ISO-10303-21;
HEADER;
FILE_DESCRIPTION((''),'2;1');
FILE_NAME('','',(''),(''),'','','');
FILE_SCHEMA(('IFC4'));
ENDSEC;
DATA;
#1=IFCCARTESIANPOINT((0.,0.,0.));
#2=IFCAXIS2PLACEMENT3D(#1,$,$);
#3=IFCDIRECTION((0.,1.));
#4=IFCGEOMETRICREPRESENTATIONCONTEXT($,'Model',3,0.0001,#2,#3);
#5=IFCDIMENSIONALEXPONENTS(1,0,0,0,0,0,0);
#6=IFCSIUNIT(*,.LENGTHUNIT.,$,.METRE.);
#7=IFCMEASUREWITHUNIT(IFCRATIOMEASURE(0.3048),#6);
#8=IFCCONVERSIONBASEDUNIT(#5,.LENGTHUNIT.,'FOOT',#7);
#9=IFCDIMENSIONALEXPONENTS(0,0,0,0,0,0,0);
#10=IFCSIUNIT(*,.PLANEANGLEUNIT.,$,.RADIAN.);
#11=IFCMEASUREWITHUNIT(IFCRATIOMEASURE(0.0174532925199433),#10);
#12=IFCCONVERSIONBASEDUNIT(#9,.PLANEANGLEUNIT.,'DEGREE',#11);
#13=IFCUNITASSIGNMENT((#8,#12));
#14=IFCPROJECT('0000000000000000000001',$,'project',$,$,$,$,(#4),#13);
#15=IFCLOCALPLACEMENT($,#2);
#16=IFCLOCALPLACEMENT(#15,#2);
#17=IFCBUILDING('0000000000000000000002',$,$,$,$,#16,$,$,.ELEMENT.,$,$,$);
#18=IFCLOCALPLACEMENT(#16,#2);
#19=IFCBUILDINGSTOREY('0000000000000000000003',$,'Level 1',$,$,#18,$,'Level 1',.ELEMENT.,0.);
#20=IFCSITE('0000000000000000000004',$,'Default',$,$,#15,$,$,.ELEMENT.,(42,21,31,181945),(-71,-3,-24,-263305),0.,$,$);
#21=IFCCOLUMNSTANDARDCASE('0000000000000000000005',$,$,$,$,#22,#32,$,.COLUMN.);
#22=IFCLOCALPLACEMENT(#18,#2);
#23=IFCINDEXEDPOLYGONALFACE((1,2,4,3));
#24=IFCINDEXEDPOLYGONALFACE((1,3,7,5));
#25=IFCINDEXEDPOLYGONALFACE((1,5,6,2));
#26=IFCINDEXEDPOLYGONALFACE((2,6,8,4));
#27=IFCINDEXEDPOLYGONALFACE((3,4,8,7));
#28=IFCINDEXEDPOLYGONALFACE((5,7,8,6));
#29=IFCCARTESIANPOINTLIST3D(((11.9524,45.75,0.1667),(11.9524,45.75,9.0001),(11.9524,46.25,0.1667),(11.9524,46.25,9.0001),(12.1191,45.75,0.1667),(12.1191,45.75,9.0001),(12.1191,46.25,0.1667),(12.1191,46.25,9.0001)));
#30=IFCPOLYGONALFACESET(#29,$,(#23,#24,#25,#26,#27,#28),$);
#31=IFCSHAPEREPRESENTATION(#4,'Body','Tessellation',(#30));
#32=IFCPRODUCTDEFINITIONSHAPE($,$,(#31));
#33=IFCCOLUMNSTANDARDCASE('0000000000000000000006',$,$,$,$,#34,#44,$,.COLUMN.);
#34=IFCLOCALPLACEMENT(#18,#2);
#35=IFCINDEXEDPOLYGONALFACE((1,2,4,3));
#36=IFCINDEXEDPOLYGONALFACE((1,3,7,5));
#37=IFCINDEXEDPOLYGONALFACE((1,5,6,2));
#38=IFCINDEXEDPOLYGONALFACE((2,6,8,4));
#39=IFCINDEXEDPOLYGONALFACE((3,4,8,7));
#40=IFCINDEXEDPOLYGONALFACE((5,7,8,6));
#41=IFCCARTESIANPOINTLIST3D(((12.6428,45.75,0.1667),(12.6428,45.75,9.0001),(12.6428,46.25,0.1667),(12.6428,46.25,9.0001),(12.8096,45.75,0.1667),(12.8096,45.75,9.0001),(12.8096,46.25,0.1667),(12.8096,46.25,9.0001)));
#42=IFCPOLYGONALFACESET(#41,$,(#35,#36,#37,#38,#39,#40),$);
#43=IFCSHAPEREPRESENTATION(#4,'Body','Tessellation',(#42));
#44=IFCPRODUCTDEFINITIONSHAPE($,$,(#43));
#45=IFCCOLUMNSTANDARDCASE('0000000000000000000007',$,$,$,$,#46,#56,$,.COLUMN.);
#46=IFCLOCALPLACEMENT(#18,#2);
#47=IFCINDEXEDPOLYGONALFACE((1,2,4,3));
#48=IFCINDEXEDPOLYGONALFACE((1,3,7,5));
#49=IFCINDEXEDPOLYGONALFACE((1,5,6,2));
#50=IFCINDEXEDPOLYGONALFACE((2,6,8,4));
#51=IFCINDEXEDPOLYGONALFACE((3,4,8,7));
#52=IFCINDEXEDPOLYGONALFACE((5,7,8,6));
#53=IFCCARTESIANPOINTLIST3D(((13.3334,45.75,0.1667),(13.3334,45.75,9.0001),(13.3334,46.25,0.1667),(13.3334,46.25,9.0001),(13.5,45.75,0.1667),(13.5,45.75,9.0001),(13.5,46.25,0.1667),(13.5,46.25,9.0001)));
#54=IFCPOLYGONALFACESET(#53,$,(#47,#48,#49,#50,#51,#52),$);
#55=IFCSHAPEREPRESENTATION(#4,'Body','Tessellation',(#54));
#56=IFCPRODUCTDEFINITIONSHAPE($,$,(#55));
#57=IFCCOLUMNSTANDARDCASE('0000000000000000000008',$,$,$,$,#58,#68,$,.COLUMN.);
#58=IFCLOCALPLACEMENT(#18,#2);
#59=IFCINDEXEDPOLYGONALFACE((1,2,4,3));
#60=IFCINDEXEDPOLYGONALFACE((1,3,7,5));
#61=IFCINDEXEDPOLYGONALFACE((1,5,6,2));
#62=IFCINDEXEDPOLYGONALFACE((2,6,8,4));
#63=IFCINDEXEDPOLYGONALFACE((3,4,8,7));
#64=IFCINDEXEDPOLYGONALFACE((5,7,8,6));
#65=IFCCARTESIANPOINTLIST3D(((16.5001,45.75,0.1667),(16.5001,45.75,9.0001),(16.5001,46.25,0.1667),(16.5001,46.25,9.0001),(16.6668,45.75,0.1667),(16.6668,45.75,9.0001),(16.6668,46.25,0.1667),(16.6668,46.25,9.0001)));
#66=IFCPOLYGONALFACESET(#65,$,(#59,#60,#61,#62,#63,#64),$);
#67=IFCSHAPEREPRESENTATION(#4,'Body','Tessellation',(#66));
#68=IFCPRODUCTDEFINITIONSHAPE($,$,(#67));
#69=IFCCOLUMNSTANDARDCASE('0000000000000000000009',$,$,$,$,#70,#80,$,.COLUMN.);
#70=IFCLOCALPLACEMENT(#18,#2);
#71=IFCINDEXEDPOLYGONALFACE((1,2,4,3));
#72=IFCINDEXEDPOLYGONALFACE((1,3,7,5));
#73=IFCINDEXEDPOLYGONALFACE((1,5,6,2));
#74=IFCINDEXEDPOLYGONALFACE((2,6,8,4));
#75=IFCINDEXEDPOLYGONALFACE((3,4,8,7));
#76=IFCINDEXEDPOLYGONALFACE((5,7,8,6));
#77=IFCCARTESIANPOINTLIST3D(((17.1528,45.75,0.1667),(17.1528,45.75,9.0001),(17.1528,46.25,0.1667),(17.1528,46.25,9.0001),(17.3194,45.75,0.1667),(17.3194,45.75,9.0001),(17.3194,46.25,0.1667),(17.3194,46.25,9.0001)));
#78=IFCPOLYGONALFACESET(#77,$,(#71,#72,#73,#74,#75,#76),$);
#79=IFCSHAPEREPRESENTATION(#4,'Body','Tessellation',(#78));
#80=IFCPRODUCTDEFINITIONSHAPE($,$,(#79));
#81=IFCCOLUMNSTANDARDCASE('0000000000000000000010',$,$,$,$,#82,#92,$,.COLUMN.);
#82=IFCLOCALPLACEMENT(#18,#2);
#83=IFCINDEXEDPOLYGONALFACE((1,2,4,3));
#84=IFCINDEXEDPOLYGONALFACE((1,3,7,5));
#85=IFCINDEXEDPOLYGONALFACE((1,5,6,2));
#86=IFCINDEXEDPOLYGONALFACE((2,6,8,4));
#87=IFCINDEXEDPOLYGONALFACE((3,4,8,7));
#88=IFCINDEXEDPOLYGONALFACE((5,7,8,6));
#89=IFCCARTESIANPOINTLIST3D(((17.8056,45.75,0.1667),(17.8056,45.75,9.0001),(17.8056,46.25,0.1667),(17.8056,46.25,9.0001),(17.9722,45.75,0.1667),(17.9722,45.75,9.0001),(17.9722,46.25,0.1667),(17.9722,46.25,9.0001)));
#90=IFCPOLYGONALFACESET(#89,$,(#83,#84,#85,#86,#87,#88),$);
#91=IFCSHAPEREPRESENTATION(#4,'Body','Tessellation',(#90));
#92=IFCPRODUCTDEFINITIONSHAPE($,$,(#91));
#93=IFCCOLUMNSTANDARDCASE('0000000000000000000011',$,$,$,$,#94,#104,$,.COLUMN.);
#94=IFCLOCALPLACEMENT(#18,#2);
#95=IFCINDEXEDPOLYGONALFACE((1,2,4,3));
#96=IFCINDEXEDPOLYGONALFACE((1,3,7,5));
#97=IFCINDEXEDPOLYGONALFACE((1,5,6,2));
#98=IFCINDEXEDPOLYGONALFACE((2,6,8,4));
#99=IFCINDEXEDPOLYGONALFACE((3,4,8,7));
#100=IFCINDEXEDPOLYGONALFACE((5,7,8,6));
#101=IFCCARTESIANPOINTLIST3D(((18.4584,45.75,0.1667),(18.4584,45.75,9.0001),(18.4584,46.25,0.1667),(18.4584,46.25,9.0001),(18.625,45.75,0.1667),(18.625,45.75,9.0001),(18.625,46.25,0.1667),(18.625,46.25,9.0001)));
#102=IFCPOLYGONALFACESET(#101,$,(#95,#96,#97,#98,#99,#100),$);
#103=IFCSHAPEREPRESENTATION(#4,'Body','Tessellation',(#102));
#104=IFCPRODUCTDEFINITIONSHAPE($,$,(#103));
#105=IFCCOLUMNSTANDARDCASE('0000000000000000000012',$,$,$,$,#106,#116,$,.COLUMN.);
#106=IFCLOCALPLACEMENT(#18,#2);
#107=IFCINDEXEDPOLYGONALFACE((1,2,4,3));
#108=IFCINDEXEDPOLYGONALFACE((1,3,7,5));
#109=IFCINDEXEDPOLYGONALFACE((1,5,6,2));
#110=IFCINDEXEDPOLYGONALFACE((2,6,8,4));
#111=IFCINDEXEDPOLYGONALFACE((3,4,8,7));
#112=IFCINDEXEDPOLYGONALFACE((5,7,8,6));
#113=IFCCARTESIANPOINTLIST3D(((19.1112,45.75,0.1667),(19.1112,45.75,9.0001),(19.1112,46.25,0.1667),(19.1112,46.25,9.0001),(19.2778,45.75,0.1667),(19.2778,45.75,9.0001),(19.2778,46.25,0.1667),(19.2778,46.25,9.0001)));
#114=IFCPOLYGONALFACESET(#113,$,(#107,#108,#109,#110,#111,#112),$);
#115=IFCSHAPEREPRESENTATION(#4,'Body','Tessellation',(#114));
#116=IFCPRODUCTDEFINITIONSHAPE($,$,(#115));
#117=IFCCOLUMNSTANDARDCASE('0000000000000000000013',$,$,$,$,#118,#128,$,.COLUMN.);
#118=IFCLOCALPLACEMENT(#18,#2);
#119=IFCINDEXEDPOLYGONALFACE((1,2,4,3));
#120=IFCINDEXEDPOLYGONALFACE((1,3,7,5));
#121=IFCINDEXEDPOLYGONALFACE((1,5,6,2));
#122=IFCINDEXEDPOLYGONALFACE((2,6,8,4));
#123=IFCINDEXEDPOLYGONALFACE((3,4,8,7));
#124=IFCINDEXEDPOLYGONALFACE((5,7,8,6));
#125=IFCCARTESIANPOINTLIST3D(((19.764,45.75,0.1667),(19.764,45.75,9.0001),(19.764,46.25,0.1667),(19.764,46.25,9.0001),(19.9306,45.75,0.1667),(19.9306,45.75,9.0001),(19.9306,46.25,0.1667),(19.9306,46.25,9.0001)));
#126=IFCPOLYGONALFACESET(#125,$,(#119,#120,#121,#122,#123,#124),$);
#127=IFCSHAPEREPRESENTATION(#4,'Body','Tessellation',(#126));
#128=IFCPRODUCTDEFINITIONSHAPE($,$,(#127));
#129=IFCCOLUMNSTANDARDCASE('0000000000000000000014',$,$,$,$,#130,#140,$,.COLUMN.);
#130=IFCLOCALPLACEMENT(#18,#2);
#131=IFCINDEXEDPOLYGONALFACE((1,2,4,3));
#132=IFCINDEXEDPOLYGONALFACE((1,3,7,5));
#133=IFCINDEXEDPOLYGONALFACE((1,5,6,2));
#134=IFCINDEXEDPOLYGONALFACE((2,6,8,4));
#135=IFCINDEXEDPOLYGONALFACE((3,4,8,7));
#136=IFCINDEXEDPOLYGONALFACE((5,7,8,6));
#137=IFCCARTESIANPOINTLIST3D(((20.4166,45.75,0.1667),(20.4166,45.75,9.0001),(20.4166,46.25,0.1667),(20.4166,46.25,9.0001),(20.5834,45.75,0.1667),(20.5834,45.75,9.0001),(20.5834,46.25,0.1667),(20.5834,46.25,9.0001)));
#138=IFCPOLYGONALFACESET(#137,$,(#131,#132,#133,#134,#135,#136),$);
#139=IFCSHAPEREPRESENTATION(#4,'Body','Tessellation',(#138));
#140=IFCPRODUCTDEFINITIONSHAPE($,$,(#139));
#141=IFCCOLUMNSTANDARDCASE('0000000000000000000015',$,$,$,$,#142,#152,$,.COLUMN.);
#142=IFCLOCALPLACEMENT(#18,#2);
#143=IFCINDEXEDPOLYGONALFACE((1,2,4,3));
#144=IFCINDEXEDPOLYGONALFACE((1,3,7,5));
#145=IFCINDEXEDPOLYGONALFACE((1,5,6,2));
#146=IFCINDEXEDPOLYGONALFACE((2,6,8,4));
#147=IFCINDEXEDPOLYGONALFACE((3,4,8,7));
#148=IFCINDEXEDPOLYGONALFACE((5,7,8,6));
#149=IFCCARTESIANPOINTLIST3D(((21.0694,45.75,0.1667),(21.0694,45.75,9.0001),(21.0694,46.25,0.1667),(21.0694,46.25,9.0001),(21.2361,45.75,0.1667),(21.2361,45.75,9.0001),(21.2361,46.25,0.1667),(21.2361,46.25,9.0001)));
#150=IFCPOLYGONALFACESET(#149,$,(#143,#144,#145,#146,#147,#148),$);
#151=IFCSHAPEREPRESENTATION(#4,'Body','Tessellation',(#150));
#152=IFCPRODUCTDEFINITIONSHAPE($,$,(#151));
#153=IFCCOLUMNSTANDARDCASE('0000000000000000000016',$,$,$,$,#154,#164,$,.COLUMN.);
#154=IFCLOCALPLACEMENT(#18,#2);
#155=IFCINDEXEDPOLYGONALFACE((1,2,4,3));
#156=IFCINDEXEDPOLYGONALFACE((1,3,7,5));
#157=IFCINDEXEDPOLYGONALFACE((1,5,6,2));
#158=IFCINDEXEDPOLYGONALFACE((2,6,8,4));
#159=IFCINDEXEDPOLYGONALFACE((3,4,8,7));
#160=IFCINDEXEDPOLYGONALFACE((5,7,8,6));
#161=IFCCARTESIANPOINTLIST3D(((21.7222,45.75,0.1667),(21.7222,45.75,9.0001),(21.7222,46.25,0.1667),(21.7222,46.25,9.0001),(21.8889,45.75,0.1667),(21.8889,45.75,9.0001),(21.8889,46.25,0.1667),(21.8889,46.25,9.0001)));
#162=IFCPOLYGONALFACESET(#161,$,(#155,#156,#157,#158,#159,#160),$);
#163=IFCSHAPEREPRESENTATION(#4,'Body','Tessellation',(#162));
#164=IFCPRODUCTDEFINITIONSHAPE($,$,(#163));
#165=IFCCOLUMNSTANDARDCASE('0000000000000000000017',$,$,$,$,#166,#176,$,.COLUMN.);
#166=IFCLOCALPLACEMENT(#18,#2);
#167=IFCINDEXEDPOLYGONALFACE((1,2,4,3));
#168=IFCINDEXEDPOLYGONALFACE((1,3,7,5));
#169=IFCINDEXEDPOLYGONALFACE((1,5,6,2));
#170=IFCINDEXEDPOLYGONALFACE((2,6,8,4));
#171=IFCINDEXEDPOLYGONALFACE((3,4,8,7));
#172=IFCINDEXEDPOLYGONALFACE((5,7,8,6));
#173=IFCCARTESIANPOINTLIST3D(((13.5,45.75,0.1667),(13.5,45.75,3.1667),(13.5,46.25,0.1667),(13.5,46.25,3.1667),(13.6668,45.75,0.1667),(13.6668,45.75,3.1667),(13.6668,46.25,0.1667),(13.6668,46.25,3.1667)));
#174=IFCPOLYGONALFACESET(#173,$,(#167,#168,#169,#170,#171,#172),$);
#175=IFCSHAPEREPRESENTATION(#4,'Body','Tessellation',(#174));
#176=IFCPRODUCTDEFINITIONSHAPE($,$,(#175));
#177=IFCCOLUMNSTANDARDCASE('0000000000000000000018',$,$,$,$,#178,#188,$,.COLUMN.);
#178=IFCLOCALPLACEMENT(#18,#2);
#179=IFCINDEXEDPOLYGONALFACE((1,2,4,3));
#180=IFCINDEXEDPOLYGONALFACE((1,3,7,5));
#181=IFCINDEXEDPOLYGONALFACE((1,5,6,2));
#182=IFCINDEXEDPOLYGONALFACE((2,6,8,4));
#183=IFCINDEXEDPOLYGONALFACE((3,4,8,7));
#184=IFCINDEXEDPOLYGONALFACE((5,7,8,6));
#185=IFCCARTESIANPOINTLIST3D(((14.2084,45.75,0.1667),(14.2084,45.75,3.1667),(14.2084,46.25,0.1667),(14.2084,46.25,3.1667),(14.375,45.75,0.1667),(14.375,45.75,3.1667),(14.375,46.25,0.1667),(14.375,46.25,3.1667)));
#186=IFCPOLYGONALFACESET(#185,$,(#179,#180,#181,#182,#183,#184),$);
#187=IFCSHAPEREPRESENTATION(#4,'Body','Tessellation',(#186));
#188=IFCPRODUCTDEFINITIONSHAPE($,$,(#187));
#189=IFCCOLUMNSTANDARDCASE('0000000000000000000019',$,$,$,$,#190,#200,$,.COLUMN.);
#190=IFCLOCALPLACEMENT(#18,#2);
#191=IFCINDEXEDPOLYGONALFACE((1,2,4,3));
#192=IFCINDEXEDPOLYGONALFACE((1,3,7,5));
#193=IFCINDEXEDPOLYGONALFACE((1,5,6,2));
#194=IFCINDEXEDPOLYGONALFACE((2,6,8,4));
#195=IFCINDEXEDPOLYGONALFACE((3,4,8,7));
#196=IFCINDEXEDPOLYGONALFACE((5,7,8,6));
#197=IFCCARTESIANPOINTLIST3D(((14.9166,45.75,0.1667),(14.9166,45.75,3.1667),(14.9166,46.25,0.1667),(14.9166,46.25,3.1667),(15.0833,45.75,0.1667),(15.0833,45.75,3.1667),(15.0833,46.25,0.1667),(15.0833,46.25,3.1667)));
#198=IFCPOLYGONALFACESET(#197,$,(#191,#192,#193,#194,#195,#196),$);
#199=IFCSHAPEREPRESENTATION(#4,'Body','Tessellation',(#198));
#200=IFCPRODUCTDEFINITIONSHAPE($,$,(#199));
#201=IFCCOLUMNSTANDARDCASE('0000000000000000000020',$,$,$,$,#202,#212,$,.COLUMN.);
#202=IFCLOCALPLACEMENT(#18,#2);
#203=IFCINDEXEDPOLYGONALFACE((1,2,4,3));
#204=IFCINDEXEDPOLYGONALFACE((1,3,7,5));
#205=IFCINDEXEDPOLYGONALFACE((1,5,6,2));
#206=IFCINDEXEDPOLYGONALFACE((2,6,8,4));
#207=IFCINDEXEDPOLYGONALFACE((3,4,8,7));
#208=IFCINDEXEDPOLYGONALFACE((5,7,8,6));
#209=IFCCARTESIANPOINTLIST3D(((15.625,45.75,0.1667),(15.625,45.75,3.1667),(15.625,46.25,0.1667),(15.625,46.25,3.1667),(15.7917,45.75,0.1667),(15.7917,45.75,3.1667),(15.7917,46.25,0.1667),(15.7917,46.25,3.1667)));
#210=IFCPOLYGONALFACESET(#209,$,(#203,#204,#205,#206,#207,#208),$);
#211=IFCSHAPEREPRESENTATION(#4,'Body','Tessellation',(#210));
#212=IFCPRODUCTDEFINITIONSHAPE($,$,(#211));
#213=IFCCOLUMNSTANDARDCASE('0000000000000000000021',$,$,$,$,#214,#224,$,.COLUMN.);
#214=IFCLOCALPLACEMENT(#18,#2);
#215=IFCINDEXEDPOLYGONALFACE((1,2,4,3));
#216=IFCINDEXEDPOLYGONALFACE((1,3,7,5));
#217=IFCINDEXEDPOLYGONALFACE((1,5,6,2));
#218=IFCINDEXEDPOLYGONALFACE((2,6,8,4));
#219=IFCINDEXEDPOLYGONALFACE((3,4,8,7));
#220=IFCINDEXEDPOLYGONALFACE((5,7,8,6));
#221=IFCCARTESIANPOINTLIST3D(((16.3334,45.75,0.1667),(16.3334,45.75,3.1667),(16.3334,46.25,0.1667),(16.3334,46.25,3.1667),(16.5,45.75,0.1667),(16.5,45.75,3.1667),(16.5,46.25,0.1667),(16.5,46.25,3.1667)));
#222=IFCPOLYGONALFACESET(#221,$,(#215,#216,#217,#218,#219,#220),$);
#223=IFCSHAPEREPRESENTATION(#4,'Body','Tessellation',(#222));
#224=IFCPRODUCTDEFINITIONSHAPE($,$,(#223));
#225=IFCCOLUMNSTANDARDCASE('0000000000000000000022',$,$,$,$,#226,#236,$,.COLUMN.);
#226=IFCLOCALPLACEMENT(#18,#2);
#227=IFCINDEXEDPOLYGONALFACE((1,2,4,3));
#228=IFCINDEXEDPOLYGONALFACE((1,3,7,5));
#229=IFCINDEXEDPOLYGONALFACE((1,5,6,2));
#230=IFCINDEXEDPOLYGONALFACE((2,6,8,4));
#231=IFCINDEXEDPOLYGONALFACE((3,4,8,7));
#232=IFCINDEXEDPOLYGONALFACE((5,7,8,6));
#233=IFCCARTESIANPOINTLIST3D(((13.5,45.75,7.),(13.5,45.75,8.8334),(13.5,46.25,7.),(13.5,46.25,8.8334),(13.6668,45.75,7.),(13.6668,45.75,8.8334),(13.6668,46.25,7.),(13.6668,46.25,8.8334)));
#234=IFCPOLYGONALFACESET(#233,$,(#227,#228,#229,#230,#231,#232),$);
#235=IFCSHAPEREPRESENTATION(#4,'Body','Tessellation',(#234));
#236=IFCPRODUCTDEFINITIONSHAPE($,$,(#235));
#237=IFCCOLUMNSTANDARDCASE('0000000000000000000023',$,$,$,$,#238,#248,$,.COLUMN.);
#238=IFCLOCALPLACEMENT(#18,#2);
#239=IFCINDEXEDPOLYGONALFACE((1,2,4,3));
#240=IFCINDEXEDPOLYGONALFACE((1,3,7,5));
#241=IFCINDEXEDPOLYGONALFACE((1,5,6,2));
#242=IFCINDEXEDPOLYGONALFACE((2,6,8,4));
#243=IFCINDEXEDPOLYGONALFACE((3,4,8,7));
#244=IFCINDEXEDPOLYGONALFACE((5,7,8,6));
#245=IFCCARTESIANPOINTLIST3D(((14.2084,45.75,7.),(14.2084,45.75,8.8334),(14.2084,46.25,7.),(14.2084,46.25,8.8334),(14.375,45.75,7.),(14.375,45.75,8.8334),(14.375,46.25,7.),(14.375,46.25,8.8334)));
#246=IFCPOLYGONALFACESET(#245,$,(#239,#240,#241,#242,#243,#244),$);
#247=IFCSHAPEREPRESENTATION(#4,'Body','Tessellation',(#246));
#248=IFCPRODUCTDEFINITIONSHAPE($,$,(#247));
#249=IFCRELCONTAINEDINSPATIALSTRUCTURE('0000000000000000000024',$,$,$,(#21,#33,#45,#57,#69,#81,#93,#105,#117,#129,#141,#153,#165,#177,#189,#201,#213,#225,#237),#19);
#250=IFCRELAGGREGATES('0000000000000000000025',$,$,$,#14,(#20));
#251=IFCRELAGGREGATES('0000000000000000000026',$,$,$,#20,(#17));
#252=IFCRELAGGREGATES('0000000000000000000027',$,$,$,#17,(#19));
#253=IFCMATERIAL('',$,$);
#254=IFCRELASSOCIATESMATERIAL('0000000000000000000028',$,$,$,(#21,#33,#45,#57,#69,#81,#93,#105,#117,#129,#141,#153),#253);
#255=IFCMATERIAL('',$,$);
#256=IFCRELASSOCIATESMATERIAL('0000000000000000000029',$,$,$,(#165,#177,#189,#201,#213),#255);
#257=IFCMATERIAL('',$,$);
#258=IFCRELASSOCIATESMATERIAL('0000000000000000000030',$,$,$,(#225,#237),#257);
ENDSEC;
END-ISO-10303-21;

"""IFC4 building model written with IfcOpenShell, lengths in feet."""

from ifc_helpers import new_model, entity, si_unit, converted_unit, direction, frame, origin, place, context, project, spatial, rectangle, extrude, material, element, save


model = new_model("IFC4")

# Units and contexts
model_context = context("Model", 3, precision=0.0001, world=origin(), true_north=direction((0.0, 1.0)))
ifc_project = project(units=[converted_unit("LENGTHUNIT", "FOOT", entity("IfcRatioMeasure", 0.3048), si_unit("LENGTHUNIT", "METRE"), dimensions=[1, 0, 0, 0, 0, 0, 0]), converted_unit("PLANEANGLEUNIT", "DEGREE", entity("IfcRatioMeasure", 0.0174532925199433), si_unit("PLANEANGLEUNIT", "RADIAN"), dimensions=[0, 0, 0, 0, 0, 0, 0])], contexts=[model_context])

# Site, building, storey
site_placement = place(None, origin())
site = spatial("IfcSite", under=ifc_project, at=site_placement, Name="Default", CompositionType="ELEMENT", RefLatitude=(42, 21, 31, 181945), RefLongitude=(-71, -3, -24, -263305), RefElevation=0.0)
building_placement = place(site_placement, origin())
building = spatial("IfcBuilding", under=site, at=building_placement, CompositionType="ELEMENT")
storey_placement = place(building_placement, origin())
storey = spatial("IfcBuildingStorey", under=building, at=storey_placement, Name="Level 1", LongName="Level 1", CompositionType="ELEMENT", Elevation=0.0)

# Columns
ifc_material_1 = material(Name="")
placement_1 = place(storey_placement, frame((-0.25, 46.0, 0.0)))
for number, where, z_axis, x_axis in (
    (1, (12.2857, 0.0, 0.1667), (0.0, 0.0, 1.0), (1.0, 0.0, 0.0)),
    (2, (12.9762, 0.0, 0.1667), (0.0, 0.0, 1.0), (1.0, 0.0, 0.0)),
    (3, (13.6667, 0.0, 0.1667), (0.0, 0.0, 1.0), (1.0, 0.0, 0.0)),
    (4, (16.8334, 0.0, 0.1667), (0.0, 0.0, 1.0), (1.0, 0.0, 0.0)),
    (5, (17.4861, 0.0, 0.1667), (0.0, 0.0, 1.0), (1.0, 0.0, 0.0)),
    (6, (18.1389, 0.0, 0.1667), (0.0, 0.0, 1.0), (1.0, 0.0, 0.0)),
    (7, (18.7917, 0.0, 0.1667), (0.0, 0.0, 1.0), (1.0, 0.0, 0.0)),
    (8, (19.4445, 0.0, 0.1667), (0.0, 0.0, 1.0), (1.0, 0.0, 0.0)),
    (9, (20.0973, 0.0, 0.1667), (0.0, 0.0, 1.0), (1.0, 0.0, 0.0)),
    (10, (20.75, 0.0, 0.1667), (0.0, 0.0, 1.0), (1.0, 0.0, 0.0)),
    (11, (21.4028, 0.0, 0.1667), (0.0, 0.0, 1.0), (1.0, 0.0, 0.0)),
    (12, (22.0556, 0.0, 0.1667), (0.0, 0.0, 1.0), (1.0, 0.0, 0.0)),
):
    element("IfcColumnStandardCase", number, at=place(placement_1, frame(where, z_axis=z_axis, x_axis=x_axis)), inside=storey, material=ifc_material_1, PredefinedType="COLUMN", context=model_context, shape_type="SweptSolid", body=[
        extrude(rectangle(XDim=0.1667, YDim=0.5), origin(), (0.0, 0.0, 1.0), 8.8334),
    ])
ifc_material_2 = material(Name="")
for number, where, z_axis, x_axis in (
    (13, (13.8334, 0.0, 0.1667), (0.0, 0.0, 1.0), (1.0, 0.0, 0.0)),
    (14, (14.5417, 0.0, 0.1667), (0.0, 0.0, 1.0), (1.0, 0.0, 0.0)),
    (15, (15.25, 0.0, 0.1667), (0.0, 0.0, 1.0), (1.0, 0.0, 0.0)),
    (16, (15.9584, 0.0, 0.1667), (0.0, 0.0, 1.0), (1.0, 0.0, 0.0)),
    (17, (16.6667, 0.0, 0.1667), (0.0, 0.0, 1.0), (1.0, 0.0, 0.0)),
):
    element("IfcColumnStandardCase", number, at=place(placement_1, frame(where, z_axis=z_axis, x_axis=x_axis)), inside=storey, material=ifc_material_2, PredefinedType="COLUMN", context=model_context, shape_type="SweptSolid", body=[
        extrude(rectangle(XDim=0.1667, YDim=0.5), origin(), (0.0, 0.0, 1.0), 3.0),
    ])
ifc_material_3 = material(Name="")
for number, where, z_axis, x_axis in (
    (18, (13.8334, 0.0, 7.0), (0.0, 0.0, 1.0), (1.0, 0.0, 0.0)),
    (19, (14.5417, 0.0, 7.0), (0.0, 0.0, 1.0), (1.0, 0.0, 0.0)),
):
    element("IfcColumnStandardCase", number, at=place(placement_1, frame(where, z_axis=z_axis, x_axis=x_axis)), inside=storey, material=ifc_material_3, PredefinedType="COLUMN", context=model_context, shape_type="SweptSolid", body=[
        extrude(rectangle(XDim=0.1667, YDim=0.5), origin(), (0.0, 0.0, 1.0), 1.8334),
    ])

save(model, "model.ifc")
